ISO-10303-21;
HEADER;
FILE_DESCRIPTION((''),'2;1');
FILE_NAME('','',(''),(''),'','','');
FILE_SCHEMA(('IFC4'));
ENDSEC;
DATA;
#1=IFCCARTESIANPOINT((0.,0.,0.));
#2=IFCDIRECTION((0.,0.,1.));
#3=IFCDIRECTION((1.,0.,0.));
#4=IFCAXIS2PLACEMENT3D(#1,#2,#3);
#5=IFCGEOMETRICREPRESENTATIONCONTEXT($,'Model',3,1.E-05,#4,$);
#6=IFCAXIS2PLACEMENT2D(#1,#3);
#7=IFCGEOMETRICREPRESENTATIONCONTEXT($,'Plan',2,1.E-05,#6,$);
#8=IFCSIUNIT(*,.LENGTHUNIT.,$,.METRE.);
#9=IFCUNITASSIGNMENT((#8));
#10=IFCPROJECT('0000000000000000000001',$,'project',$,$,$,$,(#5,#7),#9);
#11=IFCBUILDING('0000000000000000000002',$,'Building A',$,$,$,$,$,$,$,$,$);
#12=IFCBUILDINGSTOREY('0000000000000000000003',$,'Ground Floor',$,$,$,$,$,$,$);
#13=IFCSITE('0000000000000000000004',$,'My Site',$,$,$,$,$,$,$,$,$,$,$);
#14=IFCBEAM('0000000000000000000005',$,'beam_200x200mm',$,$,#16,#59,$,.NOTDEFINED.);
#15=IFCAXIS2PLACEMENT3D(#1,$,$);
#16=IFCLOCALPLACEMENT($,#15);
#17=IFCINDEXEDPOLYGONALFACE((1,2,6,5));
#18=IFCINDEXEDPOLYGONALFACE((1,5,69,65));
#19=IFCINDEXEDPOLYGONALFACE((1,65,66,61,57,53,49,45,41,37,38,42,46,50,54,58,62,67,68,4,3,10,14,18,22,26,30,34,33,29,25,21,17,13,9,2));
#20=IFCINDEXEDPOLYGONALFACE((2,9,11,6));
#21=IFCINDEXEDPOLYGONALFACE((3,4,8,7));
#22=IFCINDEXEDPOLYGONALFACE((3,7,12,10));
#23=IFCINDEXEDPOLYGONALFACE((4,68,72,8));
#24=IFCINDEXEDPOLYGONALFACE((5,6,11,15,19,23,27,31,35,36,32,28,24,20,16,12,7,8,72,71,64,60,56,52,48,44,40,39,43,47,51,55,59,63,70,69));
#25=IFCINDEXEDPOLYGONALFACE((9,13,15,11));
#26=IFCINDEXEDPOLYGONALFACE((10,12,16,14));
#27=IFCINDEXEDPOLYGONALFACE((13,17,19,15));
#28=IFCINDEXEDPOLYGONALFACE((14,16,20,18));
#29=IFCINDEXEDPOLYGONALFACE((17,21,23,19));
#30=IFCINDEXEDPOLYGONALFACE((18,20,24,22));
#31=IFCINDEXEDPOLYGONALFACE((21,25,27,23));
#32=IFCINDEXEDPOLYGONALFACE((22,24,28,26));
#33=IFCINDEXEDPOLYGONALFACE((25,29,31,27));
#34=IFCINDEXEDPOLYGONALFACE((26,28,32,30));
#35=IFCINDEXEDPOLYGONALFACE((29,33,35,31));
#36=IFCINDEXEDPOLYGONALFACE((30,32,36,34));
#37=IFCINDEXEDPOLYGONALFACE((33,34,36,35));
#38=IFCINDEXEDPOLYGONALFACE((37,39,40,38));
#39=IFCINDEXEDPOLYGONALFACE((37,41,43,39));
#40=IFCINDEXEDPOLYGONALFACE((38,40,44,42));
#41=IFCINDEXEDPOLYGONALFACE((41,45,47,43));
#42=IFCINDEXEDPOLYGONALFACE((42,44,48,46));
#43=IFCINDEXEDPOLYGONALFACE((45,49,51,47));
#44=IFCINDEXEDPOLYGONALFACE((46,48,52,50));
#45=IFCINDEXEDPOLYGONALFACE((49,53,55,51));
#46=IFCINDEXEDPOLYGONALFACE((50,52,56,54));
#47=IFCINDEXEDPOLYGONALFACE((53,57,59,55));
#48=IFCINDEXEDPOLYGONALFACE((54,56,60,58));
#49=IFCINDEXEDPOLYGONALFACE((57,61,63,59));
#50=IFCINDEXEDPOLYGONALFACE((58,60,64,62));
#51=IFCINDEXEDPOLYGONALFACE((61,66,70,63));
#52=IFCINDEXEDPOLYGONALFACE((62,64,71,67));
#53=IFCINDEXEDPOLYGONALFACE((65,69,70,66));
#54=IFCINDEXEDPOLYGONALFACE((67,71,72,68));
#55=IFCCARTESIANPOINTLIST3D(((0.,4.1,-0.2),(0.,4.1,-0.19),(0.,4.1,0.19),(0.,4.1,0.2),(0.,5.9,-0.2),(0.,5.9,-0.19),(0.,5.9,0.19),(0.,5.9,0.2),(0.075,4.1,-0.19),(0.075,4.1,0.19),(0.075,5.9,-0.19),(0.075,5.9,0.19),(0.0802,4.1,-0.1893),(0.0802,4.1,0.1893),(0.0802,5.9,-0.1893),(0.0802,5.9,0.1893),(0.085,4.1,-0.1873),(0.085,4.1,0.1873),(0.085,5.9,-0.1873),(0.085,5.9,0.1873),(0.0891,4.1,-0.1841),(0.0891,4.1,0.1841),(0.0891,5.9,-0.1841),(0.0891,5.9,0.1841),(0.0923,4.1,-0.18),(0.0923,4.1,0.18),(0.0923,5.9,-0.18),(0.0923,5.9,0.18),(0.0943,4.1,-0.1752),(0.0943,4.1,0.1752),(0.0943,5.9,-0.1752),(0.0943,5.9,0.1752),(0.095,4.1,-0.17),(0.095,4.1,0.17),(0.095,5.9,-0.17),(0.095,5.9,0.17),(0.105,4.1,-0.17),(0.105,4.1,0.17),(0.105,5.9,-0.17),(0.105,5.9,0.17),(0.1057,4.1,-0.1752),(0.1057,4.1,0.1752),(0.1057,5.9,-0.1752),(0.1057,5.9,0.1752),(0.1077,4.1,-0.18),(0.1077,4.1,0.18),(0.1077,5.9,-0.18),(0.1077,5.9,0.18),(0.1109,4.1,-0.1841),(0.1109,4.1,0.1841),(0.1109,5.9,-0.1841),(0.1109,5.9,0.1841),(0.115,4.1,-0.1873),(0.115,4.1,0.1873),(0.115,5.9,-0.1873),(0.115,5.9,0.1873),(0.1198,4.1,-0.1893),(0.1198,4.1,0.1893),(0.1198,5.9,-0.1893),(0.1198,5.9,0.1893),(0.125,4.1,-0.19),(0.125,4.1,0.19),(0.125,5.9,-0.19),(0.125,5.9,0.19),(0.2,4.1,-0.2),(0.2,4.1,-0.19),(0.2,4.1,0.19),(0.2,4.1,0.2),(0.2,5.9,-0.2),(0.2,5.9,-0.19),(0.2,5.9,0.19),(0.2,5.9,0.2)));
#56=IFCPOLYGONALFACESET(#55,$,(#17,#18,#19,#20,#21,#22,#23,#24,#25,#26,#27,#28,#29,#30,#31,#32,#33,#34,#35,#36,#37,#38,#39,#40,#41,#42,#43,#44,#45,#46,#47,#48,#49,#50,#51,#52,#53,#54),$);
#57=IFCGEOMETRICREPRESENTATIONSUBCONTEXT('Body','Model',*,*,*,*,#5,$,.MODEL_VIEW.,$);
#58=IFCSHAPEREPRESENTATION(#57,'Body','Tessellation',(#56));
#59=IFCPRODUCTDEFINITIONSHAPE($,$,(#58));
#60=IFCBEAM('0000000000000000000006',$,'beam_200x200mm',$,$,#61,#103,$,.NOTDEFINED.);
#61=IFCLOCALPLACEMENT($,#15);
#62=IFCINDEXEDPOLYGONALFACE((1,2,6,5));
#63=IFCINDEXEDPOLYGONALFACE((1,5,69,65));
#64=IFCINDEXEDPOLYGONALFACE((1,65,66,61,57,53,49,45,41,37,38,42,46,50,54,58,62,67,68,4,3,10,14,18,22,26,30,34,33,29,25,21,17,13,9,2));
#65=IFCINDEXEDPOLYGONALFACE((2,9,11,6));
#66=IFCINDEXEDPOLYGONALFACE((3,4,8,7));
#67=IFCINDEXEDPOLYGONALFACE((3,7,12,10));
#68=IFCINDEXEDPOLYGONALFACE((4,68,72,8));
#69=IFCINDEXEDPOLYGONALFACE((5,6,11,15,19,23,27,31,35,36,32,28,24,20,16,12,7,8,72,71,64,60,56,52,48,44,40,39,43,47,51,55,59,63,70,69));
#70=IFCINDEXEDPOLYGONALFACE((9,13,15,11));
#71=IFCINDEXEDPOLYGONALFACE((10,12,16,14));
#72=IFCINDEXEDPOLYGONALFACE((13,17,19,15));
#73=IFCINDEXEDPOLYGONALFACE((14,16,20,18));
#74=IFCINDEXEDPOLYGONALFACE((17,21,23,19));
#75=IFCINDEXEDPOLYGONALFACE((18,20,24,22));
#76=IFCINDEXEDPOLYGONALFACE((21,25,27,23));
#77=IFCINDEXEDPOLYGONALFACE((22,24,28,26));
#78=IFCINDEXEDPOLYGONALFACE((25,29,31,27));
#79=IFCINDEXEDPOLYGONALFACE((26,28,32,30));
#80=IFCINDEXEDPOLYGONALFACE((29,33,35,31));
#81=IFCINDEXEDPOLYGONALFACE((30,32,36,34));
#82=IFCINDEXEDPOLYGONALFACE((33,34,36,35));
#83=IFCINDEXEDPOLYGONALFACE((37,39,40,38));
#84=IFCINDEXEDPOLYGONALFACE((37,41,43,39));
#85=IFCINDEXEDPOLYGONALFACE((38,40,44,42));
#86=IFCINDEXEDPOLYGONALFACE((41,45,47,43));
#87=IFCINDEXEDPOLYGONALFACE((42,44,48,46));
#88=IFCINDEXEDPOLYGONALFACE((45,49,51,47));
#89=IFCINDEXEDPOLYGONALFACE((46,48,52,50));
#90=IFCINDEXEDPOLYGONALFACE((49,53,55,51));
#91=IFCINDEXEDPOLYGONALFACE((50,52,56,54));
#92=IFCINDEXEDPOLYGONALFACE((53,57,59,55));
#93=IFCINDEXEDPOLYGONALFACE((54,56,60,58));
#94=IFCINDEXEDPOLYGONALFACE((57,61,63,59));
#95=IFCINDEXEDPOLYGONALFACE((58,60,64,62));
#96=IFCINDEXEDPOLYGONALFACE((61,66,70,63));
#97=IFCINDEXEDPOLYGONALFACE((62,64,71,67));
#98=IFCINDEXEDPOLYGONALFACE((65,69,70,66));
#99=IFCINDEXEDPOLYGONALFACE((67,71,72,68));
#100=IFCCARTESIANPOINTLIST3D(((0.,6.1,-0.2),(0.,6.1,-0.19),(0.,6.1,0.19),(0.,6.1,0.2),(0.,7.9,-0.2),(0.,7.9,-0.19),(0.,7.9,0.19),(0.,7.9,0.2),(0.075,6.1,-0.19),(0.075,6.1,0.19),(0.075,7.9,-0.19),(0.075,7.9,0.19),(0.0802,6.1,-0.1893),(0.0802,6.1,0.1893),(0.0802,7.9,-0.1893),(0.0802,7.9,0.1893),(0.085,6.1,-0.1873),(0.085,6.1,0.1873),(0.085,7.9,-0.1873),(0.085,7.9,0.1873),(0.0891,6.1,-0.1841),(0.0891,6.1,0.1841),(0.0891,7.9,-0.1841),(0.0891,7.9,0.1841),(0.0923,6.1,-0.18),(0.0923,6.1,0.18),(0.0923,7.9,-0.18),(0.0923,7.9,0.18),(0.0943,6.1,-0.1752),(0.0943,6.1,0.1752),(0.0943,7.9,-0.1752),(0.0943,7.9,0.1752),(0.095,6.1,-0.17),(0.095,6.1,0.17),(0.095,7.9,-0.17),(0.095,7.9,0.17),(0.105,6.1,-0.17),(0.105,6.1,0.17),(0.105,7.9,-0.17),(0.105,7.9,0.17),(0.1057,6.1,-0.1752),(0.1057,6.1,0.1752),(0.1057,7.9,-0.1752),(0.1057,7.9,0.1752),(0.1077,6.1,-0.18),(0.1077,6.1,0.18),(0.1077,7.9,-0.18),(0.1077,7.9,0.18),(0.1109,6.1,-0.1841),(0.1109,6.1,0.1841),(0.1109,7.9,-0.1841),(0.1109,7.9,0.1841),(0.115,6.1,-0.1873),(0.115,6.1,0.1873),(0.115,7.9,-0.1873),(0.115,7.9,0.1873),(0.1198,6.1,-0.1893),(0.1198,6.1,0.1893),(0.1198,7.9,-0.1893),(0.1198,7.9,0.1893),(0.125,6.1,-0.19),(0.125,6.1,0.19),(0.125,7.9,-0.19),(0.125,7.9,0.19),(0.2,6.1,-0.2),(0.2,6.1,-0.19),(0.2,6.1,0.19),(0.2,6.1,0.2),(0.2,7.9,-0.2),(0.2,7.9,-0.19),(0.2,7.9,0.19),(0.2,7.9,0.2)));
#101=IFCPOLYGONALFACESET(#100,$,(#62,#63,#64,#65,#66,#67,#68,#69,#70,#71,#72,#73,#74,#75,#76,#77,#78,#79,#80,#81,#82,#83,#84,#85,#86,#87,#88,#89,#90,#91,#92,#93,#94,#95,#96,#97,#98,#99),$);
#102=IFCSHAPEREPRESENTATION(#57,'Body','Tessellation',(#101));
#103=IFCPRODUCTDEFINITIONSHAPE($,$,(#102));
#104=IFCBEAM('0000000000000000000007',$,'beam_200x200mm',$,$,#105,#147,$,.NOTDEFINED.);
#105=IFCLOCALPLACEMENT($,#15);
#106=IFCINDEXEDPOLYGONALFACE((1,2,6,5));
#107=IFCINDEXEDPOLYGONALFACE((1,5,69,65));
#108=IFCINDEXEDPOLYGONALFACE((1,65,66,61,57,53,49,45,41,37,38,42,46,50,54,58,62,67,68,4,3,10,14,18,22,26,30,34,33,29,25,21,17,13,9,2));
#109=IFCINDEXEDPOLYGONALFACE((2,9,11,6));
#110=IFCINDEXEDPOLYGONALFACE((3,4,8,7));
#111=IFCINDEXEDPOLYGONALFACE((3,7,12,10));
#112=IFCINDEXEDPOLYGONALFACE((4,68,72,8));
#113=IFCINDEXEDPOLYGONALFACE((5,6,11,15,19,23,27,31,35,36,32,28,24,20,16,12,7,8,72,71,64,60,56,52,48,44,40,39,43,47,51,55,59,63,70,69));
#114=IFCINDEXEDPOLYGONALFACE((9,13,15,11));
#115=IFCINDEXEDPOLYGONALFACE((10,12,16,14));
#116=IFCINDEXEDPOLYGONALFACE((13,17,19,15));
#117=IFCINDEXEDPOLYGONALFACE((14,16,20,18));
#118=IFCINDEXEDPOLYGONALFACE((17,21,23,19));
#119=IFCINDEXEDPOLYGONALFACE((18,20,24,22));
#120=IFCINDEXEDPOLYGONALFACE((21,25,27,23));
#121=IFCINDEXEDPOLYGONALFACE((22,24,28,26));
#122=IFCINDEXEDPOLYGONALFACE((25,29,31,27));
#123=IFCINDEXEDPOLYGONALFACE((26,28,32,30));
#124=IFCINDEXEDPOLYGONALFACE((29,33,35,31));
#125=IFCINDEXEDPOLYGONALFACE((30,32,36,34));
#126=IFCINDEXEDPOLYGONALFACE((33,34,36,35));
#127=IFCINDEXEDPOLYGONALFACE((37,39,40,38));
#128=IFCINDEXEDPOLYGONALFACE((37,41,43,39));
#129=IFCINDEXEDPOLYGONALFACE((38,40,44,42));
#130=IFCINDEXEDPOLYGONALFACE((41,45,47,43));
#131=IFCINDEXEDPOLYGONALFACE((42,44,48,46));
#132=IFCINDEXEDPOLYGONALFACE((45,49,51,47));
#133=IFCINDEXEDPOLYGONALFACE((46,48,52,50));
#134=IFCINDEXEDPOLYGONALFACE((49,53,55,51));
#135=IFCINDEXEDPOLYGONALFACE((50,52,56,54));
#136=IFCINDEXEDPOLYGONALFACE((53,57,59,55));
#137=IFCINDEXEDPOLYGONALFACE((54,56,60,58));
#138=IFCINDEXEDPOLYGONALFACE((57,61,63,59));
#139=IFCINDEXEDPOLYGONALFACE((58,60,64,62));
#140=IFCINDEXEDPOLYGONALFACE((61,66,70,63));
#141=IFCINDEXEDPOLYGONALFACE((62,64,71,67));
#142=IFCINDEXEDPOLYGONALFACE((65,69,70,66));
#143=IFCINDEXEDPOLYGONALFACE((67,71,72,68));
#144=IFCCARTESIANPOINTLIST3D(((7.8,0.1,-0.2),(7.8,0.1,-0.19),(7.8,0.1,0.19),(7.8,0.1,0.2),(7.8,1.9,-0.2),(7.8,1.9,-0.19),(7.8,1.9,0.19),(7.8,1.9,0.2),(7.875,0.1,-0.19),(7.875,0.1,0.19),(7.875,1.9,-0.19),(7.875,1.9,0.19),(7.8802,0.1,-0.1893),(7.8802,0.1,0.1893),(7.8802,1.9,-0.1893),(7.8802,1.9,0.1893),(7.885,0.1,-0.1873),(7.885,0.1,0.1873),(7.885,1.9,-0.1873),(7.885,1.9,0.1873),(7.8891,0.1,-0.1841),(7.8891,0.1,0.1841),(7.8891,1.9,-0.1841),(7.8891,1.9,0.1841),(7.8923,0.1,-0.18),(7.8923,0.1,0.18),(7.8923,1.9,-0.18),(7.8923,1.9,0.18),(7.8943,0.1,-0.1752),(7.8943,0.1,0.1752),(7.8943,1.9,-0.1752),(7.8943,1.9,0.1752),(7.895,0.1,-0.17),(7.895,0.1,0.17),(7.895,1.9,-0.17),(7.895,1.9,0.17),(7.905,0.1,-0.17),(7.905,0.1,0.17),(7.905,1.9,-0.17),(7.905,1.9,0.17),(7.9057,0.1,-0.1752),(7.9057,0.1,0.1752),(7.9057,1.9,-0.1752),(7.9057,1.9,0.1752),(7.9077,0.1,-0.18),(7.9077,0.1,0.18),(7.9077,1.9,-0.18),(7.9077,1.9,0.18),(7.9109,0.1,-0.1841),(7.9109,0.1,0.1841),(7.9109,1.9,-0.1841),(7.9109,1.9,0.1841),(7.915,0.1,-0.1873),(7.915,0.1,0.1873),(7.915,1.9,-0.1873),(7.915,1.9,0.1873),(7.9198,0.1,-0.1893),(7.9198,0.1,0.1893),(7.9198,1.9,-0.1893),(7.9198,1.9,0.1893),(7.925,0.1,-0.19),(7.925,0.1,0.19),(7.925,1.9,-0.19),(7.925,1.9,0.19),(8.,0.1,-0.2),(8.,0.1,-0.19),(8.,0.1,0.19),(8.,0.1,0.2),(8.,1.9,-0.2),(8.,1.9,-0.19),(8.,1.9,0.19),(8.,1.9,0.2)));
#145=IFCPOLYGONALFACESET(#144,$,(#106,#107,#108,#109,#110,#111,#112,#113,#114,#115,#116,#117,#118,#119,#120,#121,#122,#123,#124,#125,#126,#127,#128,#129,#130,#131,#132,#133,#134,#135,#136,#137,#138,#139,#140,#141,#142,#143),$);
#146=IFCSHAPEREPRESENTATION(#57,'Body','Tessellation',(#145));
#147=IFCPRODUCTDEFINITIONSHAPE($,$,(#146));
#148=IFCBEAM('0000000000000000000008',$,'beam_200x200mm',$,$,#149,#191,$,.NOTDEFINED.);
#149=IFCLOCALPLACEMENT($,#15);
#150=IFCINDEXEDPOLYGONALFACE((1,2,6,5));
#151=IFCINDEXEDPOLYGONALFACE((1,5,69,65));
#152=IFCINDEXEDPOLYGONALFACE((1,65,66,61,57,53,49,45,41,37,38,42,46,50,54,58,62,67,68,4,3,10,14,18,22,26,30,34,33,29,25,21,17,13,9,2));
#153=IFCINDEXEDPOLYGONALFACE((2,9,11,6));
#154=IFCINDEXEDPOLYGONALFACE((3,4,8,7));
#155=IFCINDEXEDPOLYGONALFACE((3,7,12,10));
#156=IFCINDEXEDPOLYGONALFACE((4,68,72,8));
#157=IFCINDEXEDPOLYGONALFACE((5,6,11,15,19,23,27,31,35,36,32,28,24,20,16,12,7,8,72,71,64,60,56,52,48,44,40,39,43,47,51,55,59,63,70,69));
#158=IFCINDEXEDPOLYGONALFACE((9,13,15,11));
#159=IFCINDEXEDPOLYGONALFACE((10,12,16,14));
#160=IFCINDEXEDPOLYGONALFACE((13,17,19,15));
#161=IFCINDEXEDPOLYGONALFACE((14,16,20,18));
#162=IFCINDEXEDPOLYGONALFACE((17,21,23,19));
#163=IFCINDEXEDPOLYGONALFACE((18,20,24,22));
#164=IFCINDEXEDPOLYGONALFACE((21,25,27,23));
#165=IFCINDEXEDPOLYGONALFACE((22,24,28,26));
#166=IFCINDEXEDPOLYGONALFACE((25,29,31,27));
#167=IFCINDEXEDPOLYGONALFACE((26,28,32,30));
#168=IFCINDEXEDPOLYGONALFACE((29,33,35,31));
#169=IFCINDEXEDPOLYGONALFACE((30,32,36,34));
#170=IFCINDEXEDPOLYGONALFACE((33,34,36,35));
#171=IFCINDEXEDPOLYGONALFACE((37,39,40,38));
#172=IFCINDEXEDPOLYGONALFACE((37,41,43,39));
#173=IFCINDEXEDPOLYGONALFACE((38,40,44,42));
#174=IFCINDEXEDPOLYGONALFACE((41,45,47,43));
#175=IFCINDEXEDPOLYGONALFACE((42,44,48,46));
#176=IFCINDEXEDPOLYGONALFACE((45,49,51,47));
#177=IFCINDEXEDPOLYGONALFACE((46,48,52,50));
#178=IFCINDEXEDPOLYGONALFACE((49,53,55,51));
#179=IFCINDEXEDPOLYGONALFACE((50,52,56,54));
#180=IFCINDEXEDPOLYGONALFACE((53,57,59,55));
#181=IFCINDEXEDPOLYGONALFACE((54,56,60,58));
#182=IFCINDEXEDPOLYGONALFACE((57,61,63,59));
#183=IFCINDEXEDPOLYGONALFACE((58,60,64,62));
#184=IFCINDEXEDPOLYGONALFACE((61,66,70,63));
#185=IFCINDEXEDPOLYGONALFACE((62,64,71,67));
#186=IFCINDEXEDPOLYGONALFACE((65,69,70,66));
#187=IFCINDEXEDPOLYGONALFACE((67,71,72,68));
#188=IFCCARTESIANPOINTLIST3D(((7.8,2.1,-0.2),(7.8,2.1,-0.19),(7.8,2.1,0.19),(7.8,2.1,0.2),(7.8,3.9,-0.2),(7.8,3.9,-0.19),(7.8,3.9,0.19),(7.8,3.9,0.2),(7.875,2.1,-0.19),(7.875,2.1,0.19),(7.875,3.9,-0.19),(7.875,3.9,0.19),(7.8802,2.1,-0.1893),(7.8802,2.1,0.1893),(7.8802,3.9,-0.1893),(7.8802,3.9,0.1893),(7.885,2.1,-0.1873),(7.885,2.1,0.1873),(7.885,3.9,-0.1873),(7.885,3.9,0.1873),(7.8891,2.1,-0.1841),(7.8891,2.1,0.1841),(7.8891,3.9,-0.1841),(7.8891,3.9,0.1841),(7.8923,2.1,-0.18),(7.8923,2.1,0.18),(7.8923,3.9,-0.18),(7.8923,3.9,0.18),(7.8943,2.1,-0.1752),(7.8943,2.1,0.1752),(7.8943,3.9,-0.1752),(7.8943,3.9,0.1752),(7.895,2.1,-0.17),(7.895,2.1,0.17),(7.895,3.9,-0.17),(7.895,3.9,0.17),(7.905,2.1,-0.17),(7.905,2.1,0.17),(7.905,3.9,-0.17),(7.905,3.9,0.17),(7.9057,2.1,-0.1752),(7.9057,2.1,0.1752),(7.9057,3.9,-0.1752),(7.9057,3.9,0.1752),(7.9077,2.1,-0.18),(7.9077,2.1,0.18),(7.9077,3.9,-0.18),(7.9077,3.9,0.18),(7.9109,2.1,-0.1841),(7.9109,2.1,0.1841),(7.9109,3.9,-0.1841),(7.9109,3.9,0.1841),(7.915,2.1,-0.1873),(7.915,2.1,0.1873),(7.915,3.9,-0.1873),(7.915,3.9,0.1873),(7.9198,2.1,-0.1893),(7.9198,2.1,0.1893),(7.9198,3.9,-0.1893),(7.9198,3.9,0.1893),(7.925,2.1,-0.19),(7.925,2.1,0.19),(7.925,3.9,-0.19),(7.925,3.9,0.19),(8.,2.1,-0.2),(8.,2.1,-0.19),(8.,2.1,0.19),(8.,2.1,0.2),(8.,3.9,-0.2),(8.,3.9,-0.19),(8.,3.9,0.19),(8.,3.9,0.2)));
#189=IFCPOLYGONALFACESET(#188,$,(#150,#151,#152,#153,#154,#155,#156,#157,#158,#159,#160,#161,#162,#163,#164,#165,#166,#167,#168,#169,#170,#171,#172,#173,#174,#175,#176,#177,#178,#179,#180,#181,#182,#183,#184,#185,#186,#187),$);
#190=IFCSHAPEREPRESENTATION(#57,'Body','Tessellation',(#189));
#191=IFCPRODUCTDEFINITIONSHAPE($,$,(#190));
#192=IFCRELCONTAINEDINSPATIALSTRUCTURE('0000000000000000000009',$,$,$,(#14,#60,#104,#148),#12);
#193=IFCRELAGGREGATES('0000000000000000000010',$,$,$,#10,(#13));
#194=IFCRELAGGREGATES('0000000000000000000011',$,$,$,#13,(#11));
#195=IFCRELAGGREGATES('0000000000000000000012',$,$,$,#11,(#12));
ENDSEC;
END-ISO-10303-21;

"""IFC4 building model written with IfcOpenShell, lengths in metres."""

from ifc_helpers import new_model, entity, si_unit, frame, frame_2d, origin_with_axes, place, context, subcontext, project, spatial, extrude, element, save


model = new_model("IFC4")

# Units and contexts
model_context = context("Model", 3, precision=1e-05, world=origin_with_axes())
plan_context = context("Plan", 2, precision=1e-05, world=frame_2d((0.0, 0.0, 0.0), x_axis=(1.0, 0.0, 0.0)))
body_context = subcontext(model_context, "Body", "Model", "MODEL_VIEW")
ifc_project = project(units=[si_unit("LENGTHUNIT", "METRE")], contexts=[model_context, plan_context])

# Site, building, storey
site = spatial("IfcSite", under=ifc_project, Name="My Site")
building = spatial("IfcBuilding", under=site, Name="Building A")
storey = spatial("IfcBuildingStorey", under=building, Name="Ground Floor")

# Beams
for number, where, z_axis, x_axis, name in (
    (1, (0.1, 4.1, 0.0), (0.0, 1.0, 0.0), (1.0, 1.0, 0.0), "beam_200x200mm"),
    (2, (0.1, 6.1, 0.0), (0.0, 1.0, 0.0), (1.0, 1.0, 0.0), "beam_200x200mm"),
    (3, (7.9, 0.1, 0.0), (0.0, 1.0, 0.0), (1.0, 1.0, 0.0), "beam_200x200mm"),
    (4, (7.9, 2.1, 0.0), (0.0, 1.0, 0.0), (1.0, 1.0, 0.0), "beam_200x200mm"),
):
    element("IfcBeam", number, at=place(None, frame(where, z_axis=z_axis, x_axis=x_axis)), inside=storey, Name=name, PredefinedType="NOTDEFINED", context=body_context, shape_type="SweptSolid", body=[
        extrude(entity("IfcIShapeProfileDef", None, None, None, 0.2, 0.4, 0.01, 0.01, 0.02), origin_with_axes(), (0.0, 0.0, 1.0), 1.8),
    ])

save(model, "model.ifc")
